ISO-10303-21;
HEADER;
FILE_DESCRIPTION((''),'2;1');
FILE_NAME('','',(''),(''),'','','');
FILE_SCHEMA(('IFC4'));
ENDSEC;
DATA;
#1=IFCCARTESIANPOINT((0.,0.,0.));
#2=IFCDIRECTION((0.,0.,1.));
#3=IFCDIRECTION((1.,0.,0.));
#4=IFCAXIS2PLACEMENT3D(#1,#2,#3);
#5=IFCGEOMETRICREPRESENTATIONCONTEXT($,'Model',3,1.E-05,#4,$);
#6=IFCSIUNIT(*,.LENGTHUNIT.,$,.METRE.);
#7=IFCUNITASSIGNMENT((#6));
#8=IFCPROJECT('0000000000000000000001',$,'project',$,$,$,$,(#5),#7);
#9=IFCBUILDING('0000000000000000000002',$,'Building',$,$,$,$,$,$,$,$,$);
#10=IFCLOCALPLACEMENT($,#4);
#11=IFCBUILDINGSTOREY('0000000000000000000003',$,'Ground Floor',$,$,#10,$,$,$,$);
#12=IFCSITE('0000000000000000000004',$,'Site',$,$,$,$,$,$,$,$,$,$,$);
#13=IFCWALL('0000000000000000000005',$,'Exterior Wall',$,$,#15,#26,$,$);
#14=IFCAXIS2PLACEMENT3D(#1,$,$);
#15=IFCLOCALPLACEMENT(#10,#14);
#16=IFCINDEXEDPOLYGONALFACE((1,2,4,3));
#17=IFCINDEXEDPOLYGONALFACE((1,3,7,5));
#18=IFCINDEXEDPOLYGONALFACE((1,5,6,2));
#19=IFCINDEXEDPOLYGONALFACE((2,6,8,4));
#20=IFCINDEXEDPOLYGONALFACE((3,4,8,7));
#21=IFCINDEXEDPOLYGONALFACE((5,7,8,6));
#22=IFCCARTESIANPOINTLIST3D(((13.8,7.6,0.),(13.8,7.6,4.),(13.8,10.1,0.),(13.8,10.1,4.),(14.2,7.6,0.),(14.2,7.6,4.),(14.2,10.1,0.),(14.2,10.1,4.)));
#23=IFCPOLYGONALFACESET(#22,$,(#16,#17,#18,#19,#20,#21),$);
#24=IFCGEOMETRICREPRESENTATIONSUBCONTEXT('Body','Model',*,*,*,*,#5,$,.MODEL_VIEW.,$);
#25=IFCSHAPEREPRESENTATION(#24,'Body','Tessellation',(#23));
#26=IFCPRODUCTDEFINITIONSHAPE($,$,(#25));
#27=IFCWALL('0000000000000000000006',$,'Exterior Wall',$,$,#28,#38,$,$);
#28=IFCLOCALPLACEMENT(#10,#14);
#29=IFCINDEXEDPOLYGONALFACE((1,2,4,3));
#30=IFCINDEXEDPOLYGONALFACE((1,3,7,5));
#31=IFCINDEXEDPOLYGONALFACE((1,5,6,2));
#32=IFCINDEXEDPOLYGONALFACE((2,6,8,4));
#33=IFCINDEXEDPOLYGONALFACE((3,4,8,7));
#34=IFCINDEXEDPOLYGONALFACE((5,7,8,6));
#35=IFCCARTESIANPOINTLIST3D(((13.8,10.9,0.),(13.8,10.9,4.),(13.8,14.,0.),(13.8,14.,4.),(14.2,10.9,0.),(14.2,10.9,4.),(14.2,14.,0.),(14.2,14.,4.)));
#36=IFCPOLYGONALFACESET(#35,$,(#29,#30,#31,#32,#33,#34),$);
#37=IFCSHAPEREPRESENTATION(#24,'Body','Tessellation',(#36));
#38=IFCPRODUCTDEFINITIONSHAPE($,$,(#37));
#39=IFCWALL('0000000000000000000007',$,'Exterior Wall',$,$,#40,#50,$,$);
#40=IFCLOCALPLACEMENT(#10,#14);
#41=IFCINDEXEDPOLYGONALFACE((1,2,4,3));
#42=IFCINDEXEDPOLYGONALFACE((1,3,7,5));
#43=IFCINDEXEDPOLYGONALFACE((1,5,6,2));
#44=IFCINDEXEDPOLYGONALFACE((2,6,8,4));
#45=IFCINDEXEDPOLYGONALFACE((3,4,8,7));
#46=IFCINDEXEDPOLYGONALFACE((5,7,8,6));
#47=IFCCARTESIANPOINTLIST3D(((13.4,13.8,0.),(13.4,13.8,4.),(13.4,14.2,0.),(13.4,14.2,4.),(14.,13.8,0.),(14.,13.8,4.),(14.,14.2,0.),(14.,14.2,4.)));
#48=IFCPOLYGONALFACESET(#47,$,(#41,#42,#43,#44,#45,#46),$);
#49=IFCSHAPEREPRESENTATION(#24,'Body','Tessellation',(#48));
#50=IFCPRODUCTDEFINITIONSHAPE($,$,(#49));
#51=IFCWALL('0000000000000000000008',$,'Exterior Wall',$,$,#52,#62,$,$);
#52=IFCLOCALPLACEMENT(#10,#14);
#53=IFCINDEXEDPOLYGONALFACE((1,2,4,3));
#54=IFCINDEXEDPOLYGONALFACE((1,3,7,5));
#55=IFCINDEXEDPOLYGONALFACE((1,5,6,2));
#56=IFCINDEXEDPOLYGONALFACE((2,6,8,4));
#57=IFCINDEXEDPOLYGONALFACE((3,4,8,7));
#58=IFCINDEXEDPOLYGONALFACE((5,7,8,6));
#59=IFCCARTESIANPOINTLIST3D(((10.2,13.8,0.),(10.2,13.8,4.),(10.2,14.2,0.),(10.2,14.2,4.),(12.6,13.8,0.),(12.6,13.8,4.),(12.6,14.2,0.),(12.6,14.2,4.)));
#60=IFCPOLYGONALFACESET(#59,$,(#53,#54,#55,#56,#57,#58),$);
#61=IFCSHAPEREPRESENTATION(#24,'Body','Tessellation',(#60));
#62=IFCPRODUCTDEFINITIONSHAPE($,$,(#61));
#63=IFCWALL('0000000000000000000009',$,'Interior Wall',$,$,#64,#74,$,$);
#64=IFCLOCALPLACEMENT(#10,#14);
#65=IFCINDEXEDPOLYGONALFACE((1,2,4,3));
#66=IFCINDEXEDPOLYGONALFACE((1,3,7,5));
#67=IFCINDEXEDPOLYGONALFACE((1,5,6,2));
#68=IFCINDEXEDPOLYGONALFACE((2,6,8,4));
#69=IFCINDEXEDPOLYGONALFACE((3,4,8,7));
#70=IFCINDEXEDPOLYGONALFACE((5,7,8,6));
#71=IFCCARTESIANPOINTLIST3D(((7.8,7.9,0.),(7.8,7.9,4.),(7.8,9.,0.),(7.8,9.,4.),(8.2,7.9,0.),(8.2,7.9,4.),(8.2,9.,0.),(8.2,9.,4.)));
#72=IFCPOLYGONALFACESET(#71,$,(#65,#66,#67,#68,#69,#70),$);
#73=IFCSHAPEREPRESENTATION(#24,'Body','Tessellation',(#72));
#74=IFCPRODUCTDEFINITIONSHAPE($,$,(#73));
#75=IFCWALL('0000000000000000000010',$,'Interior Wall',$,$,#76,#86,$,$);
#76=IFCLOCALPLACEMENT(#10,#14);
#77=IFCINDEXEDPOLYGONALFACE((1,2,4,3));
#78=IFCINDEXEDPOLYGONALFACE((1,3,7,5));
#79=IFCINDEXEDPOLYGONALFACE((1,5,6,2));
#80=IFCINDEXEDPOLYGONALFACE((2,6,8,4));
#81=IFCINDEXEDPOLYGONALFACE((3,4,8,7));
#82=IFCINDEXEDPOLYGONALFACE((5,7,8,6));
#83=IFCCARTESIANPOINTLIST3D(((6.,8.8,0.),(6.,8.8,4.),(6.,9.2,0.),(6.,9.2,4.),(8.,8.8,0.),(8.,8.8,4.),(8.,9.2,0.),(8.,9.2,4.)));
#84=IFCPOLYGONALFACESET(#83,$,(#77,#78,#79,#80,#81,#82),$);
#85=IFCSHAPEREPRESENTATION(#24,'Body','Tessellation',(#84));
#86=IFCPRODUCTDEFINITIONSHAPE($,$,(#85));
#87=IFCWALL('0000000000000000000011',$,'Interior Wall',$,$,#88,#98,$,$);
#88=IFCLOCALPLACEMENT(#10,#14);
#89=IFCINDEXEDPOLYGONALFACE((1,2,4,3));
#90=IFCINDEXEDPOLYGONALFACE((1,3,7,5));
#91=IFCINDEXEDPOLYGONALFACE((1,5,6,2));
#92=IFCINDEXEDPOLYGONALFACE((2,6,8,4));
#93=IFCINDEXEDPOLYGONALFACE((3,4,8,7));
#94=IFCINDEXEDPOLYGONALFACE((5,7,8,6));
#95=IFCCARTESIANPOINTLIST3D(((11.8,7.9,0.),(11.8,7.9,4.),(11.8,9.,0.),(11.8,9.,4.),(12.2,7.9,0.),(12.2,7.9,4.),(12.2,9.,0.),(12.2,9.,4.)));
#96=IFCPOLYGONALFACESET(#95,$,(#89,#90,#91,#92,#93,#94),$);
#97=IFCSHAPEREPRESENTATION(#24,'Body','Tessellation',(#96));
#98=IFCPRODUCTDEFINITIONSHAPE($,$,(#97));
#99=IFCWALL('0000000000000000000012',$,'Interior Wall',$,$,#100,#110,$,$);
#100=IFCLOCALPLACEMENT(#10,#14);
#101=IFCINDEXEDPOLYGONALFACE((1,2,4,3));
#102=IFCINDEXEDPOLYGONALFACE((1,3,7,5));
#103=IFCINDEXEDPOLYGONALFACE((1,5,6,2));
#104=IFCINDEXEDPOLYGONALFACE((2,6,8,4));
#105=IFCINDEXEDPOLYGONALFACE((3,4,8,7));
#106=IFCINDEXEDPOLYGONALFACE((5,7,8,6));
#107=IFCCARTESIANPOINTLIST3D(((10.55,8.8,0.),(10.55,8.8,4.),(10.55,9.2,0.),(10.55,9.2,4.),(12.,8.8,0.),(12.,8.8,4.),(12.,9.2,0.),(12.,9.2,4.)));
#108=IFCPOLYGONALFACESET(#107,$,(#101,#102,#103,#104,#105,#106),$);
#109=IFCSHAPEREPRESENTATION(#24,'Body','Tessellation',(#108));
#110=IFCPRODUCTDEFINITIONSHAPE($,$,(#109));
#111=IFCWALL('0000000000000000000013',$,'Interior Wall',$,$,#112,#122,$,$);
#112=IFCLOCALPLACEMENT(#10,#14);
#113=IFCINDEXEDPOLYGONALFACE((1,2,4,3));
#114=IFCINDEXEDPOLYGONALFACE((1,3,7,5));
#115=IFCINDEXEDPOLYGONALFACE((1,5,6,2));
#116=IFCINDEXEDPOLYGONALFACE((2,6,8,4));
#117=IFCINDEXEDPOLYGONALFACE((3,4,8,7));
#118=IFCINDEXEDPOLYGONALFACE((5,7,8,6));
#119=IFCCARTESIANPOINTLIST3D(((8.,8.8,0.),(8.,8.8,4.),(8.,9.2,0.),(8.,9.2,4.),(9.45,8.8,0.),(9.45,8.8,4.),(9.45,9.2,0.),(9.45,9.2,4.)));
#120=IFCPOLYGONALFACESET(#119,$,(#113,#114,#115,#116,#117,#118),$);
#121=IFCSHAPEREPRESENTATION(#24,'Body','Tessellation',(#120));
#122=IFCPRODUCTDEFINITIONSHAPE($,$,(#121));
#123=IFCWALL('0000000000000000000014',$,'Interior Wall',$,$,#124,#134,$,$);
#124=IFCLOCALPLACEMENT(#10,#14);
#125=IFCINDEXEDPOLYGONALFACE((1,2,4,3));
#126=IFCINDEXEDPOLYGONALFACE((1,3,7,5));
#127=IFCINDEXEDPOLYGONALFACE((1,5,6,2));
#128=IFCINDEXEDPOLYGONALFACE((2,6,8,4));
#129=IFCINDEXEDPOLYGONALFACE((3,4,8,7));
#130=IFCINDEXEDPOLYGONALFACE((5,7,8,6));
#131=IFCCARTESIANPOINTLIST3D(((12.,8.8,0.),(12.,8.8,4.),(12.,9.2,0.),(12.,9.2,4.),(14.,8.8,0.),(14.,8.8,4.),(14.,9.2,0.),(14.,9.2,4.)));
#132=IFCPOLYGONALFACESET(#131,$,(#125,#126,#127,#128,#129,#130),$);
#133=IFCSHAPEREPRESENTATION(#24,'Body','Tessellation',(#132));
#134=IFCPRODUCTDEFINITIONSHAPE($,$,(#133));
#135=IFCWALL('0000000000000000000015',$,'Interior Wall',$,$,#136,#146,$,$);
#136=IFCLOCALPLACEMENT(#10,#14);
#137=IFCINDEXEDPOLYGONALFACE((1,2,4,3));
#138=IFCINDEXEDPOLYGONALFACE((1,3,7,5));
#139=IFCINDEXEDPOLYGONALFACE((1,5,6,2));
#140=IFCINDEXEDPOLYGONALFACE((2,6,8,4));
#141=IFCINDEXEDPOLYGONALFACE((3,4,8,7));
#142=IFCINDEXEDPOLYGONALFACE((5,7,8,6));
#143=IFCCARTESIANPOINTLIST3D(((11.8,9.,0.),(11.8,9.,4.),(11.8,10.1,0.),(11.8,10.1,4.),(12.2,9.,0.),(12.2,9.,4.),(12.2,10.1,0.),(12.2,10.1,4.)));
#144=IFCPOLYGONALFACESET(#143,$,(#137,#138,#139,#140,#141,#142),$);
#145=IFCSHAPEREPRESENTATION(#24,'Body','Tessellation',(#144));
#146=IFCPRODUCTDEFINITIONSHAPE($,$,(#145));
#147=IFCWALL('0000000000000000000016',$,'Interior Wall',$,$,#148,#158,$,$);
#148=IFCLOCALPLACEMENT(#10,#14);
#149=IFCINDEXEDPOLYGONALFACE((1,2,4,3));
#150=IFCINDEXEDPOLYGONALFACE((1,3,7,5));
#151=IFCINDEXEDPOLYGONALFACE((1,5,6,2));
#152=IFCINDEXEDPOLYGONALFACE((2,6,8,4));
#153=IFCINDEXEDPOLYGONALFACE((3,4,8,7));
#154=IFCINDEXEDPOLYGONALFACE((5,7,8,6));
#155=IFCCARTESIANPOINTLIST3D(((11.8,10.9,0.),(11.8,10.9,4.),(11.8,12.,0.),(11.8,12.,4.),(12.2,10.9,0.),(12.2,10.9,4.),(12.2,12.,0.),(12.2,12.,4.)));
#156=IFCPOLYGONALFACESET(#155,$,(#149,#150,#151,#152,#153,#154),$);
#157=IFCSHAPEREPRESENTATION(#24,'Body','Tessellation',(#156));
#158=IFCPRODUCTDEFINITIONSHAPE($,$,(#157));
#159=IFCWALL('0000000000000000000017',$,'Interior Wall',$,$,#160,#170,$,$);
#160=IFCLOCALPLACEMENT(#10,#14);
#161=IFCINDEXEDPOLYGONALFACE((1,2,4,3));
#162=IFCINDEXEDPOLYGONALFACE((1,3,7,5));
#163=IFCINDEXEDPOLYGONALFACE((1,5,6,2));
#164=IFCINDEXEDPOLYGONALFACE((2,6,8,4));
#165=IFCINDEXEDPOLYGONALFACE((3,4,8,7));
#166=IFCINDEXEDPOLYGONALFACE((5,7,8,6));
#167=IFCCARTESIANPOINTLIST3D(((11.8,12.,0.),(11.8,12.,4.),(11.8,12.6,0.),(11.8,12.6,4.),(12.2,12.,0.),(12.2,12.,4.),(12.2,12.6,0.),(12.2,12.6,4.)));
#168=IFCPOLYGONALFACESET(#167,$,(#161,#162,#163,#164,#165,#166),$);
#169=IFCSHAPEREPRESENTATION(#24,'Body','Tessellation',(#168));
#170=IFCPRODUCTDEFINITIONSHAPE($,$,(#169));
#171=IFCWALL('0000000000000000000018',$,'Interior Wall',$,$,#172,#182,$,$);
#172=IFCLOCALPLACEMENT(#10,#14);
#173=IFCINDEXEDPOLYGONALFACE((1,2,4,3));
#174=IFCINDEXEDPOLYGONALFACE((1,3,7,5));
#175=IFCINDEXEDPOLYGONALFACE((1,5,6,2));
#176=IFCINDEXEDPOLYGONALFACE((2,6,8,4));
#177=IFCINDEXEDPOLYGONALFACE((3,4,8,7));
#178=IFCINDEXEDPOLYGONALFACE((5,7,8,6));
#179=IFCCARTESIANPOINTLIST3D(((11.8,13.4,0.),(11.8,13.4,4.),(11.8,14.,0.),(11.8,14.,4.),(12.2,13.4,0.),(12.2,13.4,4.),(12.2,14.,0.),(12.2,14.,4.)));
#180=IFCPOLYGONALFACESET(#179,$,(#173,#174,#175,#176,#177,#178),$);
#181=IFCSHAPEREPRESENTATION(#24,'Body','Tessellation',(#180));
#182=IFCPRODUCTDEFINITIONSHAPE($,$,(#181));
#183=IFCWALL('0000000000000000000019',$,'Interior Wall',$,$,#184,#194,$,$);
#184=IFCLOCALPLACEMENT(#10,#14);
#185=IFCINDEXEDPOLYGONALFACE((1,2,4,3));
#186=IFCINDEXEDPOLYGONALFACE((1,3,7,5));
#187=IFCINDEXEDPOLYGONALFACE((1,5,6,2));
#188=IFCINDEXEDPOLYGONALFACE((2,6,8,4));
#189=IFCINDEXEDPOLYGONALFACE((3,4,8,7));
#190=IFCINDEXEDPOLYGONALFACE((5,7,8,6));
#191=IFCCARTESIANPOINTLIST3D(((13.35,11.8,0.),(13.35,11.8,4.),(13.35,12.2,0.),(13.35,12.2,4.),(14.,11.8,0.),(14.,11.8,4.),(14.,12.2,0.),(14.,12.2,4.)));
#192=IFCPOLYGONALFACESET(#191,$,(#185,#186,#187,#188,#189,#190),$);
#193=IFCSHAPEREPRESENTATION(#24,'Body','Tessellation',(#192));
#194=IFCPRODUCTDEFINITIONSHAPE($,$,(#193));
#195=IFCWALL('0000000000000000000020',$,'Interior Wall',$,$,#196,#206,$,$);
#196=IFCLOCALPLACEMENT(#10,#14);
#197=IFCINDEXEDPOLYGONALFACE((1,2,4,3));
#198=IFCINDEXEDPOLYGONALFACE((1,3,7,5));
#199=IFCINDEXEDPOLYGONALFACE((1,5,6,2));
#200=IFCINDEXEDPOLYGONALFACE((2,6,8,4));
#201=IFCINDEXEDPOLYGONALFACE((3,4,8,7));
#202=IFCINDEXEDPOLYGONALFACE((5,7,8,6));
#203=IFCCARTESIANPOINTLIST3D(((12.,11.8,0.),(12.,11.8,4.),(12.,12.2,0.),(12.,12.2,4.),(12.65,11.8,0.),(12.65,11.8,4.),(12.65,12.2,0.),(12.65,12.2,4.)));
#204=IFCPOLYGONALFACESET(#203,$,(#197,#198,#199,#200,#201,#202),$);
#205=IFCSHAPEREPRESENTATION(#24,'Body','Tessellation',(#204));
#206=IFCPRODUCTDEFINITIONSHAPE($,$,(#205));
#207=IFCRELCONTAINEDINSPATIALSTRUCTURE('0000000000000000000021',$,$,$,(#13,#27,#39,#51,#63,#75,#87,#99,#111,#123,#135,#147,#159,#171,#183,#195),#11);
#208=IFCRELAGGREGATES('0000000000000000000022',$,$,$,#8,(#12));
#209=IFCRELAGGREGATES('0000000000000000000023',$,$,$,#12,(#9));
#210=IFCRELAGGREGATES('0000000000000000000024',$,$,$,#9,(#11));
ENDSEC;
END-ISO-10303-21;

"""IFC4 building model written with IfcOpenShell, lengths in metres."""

from ifc_helpers import new_model, si_unit, frame, origin_with_axes, place, context, subcontext, project, spatial, indexed_curve, outline, extrude, element, save


model = new_model("IFC4")

# Units and contexts
model_context = context("Model", 3, precision=1e-05, world=origin_with_axes())
body_context = subcontext(model_context, "Body", "Model", "MODEL_VIEW")
ifc_project = project(units=[si_unit("LENGTHUNIT", "METRE")], contexts=[model_context])

# Site, building, storey
site = spatial("IfcSite", under=ifc_project, Name="Site")
building = spatial("IfcBuilding", under=site, Name="Building")
storey_placement = place(None, origin_with_axes())
storey = spatial("IfcBuildingStorey", under=building, at=storey_placement, Name="Ground Floor")

# Walls
wall_1_placement = place(storey_placement, frame((14.0, 7.6, 0.0), z_axis=(0.0, 0.0, 1.0), x_axis=(0.0, 1.0, 0.0)))
element("IfcWall", 1, at=wall_1_placement, inside=storey, Name="Exterior Wall", context=body_context, shape_type="SweptSolid", body=[
    extrude(outline(indexed_curve([(0.0, 0.0), (0.0, 0.4), (2.5, 0.4), (2.5, 0.0), (0.0, 0.0)], self_intersect=False)), frame((0.0, -0.2, 0.0), z_axis=(0.0, 0.0, 1.0), x_axis=(1.0, 0.0, 0.0)), (0.0, 0.0, 1.0), 4.0),
])
wall_2_placement = place(storey_placement, frame((14.0, 10.9, 0.0), z_axis=(0.0, 0.0, 1.0), x_axis=(0.0, 1.0, 0.0)))
element("IfcWall", 2, at=wall_2_placement, inside=storey, Name="Exterior Wall", context=body_context, shape_type="SweptSolid", body=[
    extrude(outline(indexed_curve([(0.0, 0.0), (0.0, 0.4), (3.1, 0.4), (3.1, 0.0), (0.0, 0.0)], self_intersect=False)), frame((0.0, -0.2, 0.0), z_axis=(0.0, 0.0, 1.0), x_axis=(1.0, 0.0, 0.0)), (0.0, 0.0, 1.0), 4.0),
])
wall_3_placement = place(storey_placement, frame((14.0, 14.0, 0.0), z_axis=(0.0, 0.0, 1.0), x_axis=(-1.0, 0.0, 0.0)))
element("IfcWall", 3, at=wall_3_placement, inside=storey, Name="Exterior Wall", context=body_context, shape_type="SweptSolid", body=[
    extrude(outline(indexed_curve([(0.0, 0.0), (0.0, 0.4), (0.6, 0.4), (0.6, 0.0), (0.0, 0.0)], self_intersect=False)), frame((0.0, -0.2, 0.0), z_axis=(0.0, 0.0, 1.0), x_axis=(1.0, 0.0, 0.0)), (0.0, 0.0, 1.0), 4.0),
])
wall_4_placement = place(storey_placement, frame((12.6, 14.0, 0.0), z_axis=(0.0, 0.0, 1.0), x_axis=(-1.0, 0.0, 0.0)))
element("IfcWall", 4, at=wall_4_placement, inside=storey, Name="Exterior Wall", context=body_context, shape_type="SweptSolid", body=[
    extrude(outline(indexed_curve([(0.0, 0.0), (0.0, 0.4), (2.4, 0.4), (2.4, 0.0), (0.0, 0.0)], self_intersect=False)), frame((0.0, -0.2, 0.0), z_axis=(0.0, 0.0, 1.0), x_axis=(1.0, 0.0, 0.0)), (0.0, 0.0, 1.0), 4.0),
])
wall_5_placement = place(storey_placement, frame((8.0, 7.9, 0.0), z_axis=(0.0, 0.0, 1.0), x_axis=(0.0, 1.0, 0.0)))
element("IfcWall", 5, at=wall_5_placement, inside=storey, Name="Interior Wall", context=body_context, shape_type="SweptSolid", body=[
    extrude(outline(indexed_curve([(0.0, 0.0), (0.0, 0.4), (1.1, 0.4), (1.1, 0.0), (0.0, 0.0)], self_intersect=False)), frame((0.0, -0.2, 0.0), z_axis=(0.0, 0.0, 1.0), x_axis=(1.0, 0.0, 0.0)), (0.0, 0.0, 1.0), 4.0),
])
wall_6_placement = place(storey_placement, frame((8.0, 9.0, 0.0), z_axis=(0.0, 0.0, 1.0), x_axis=(-1.0, 0.0, 0.0)))
element("IfcWall", 6, at=wall_6_placement, inside=storey, Name="Interior Wall", context=body_context, shape_type="SweptSolid", body=[
    extrude(outline(indexed_curve([(0.0, 0.0), (0.0, 0.4), (2.0, 0.4), (2.0, 0.0), (0.0, 0.0)], self_intersect=False)), frame((0.0, -0.2, 0.0), z_axis=(0.0, 0.0, 1.0), x_axis=(1.0, 0.0, 0.0)), (0.0, 0.0, 1.0), 4.0),
])
wall_7_placement = place(storey_placement, frame((12.0, 7.9, 0.0), z_axis=(0.0, 0.0, 1.0), x_axis=(0.0, 1.0, 0.0)))
element("IfcWall", 7, at=wall_7_placement, inside=storey, Name="Interior Wall", context=body_context, shape_type="SweptSolid", body=[
    extrude(outline(indexed_curve([(0.0, 0.0), (0.0, 0.4), (1.1, 0.4), (1.1, 0.0), (0.0, 0.0)], self_intersect=False)), frame((0.0, -0.2, 0.0), z_axis=(0.0, 0.0, 1.0), x_axis=(1.0, 0.0, 0.0)), (0.0, 0.0, 1.0), 4.0),
])
for number, where, z_axis, x_axis, name in (
    (8, (12.0, 9.0, 0.0), (0.0, 0.0, 1.0), (-1.0, 0.0, 0.0), "Interior Wall"),
    (9, (9.45, 9.0, 0.0), (0.0, 0.0, 1.0), (-1.0, 0.0, 0.0), "Interior Wall"),
):
    element("IfcWall", number, at=place(storey_placement, frame(where, z_axis=z_axis, x_axis=x_axis)), inside=storey, Name=name, context=body_context, shape_type="SweptSolid", body=[
        extrude(outline(indexed_curve([(0.0, 0.0), (0.0, 0.4), (1.45, 0.4), (1.45, 0.0), (0.0, 0.0)], self_intersect=False)), frame((0.0, -0.2, 0.0), z_axis=(0.0, 0.0, 1.0), x_axis=(1.0, 0.0, 0.0)), (0.0, 0.0, 1.0), 4.0),
    ])
wall_8_placement = place(storey_placement, frame((14.0, 9.0, 0.0), z_axis=(0.0, 0.0, 1.0), x_axis=(-1.0, 0.0, 0.0)))
element("IfcWall", 10, at=wall_8_placement, inside=storey, Name="Interior Wall", context=body_context, shape_type="SweptSolid", body=[
    extrude(outline(indexed_curve([(0.0, 0.0), (0.0, 0.4), (2.0, 0.4), (2.0, 0.0), (0.0, 0.0)], self_intersect=False)), frame((0.0, -0.2, 0.0), z_axis=(0.0, 0.0, 1.0), x_axis=(1.0, 0.0, 0.0)), (0.0, 0.0, 1.0), 4.0),
])
for number, where, z_axis, x_axis, name in (
    (11, (12.0, 9.0, 0.0), (0.0, 0.0, 1.0), (0.0, 1.0, 0.0), "Interior Wall"),
    (12, (12.0, 10.9, 0.0), (0.0, 0.0, 1.0), (0.0, 1.0, 0.0), "Interior Wall"),
):
    element("IfcWall", number, at=place(storey_placement, frame(where, z_axis=z_axis, x_axis=x_axis)), inside=storey, Name=name, context=body_context, shape_type="SweptSolid", body=[
        extrude(outline(indexed_curve([(0.0, 0.0), (0.0, 0.4), (1.1, 0.4), (1.1, 0.0), (0.0, 0.0)], self_intersect=False)), frame((0.0, -0.2, 0.0), z_axis=(0.0, 0.0, 1.0), x_axis=(1.0, 0.0, 0.0)), (0.0, 0.0, 1.0), 4.0),
    ])
for number, where, z_axis, x_axis, name in (
    (13, (12.0, 12.0, 0.0), (0.0, 0.0, 1.0), (0.0, 1.0, 0.0), "Interior Wall"),
    (14, (12.0, 13.4, 0.0), (0.0, 0.0, 1.0), (0.0, 1.0, 0.0), "Interior Wall"),
):
    element("IfcWall", number, at=place(storey_placement, frame(where, z_axis=z_axis, x_axis=x_axis)), inside=storey, Name=name, context=body_context, shape_type="SweptSolid", body=[
        extrude(outline(indexed_curve([(0.0, 0.0), (0.0, 0.4), (0.6, 0.4), (0.6, 0.0), (0.0, 0.0)], self_intersect=False)), frame((0.0, -0.2, 0.0), z_axis=(0.0, 0.0, 1.0), x_axis=(1.0, 0.0, 0.0)), (0.0, 0.0, 1.0), 4.0),
    ])
for number, where, z_axis, x_axis, name in (
    (15, (14.0, 12.0, 0.0), (0.0, 0.0, 1.0), (-1.0, 0.0, 0.0), "Interior Wall"),
    (16, (12.65, 12.0, 0.0), (0.0, 0.0, 1.0), (-1.0, 0.0, 0.0), "Interior Wall"),
):
    element("IfcWall", number, at=place(storey_placement, frame(where, z_axis=z_axis, x_axis=x_axis)), inside=storey, Name=name, context=body_context, shape_type="SweptSolid", body=[
        extrude(outline(indexed_curve([(0.0, 0.0), (0.0, 0.4), (0.65, 0.4), (0.65, 0.0), (0.0, 0.0)], self_intersect=False)), frame((0.0, -0.2, 0.0), z_axis=(0.0, 0.0, 1.0), x_axis=(1.0, 0.0, 0.0)), (0.0, 0.0, 1.0), 4.0),
    ])

save(model, "model.ifc")
